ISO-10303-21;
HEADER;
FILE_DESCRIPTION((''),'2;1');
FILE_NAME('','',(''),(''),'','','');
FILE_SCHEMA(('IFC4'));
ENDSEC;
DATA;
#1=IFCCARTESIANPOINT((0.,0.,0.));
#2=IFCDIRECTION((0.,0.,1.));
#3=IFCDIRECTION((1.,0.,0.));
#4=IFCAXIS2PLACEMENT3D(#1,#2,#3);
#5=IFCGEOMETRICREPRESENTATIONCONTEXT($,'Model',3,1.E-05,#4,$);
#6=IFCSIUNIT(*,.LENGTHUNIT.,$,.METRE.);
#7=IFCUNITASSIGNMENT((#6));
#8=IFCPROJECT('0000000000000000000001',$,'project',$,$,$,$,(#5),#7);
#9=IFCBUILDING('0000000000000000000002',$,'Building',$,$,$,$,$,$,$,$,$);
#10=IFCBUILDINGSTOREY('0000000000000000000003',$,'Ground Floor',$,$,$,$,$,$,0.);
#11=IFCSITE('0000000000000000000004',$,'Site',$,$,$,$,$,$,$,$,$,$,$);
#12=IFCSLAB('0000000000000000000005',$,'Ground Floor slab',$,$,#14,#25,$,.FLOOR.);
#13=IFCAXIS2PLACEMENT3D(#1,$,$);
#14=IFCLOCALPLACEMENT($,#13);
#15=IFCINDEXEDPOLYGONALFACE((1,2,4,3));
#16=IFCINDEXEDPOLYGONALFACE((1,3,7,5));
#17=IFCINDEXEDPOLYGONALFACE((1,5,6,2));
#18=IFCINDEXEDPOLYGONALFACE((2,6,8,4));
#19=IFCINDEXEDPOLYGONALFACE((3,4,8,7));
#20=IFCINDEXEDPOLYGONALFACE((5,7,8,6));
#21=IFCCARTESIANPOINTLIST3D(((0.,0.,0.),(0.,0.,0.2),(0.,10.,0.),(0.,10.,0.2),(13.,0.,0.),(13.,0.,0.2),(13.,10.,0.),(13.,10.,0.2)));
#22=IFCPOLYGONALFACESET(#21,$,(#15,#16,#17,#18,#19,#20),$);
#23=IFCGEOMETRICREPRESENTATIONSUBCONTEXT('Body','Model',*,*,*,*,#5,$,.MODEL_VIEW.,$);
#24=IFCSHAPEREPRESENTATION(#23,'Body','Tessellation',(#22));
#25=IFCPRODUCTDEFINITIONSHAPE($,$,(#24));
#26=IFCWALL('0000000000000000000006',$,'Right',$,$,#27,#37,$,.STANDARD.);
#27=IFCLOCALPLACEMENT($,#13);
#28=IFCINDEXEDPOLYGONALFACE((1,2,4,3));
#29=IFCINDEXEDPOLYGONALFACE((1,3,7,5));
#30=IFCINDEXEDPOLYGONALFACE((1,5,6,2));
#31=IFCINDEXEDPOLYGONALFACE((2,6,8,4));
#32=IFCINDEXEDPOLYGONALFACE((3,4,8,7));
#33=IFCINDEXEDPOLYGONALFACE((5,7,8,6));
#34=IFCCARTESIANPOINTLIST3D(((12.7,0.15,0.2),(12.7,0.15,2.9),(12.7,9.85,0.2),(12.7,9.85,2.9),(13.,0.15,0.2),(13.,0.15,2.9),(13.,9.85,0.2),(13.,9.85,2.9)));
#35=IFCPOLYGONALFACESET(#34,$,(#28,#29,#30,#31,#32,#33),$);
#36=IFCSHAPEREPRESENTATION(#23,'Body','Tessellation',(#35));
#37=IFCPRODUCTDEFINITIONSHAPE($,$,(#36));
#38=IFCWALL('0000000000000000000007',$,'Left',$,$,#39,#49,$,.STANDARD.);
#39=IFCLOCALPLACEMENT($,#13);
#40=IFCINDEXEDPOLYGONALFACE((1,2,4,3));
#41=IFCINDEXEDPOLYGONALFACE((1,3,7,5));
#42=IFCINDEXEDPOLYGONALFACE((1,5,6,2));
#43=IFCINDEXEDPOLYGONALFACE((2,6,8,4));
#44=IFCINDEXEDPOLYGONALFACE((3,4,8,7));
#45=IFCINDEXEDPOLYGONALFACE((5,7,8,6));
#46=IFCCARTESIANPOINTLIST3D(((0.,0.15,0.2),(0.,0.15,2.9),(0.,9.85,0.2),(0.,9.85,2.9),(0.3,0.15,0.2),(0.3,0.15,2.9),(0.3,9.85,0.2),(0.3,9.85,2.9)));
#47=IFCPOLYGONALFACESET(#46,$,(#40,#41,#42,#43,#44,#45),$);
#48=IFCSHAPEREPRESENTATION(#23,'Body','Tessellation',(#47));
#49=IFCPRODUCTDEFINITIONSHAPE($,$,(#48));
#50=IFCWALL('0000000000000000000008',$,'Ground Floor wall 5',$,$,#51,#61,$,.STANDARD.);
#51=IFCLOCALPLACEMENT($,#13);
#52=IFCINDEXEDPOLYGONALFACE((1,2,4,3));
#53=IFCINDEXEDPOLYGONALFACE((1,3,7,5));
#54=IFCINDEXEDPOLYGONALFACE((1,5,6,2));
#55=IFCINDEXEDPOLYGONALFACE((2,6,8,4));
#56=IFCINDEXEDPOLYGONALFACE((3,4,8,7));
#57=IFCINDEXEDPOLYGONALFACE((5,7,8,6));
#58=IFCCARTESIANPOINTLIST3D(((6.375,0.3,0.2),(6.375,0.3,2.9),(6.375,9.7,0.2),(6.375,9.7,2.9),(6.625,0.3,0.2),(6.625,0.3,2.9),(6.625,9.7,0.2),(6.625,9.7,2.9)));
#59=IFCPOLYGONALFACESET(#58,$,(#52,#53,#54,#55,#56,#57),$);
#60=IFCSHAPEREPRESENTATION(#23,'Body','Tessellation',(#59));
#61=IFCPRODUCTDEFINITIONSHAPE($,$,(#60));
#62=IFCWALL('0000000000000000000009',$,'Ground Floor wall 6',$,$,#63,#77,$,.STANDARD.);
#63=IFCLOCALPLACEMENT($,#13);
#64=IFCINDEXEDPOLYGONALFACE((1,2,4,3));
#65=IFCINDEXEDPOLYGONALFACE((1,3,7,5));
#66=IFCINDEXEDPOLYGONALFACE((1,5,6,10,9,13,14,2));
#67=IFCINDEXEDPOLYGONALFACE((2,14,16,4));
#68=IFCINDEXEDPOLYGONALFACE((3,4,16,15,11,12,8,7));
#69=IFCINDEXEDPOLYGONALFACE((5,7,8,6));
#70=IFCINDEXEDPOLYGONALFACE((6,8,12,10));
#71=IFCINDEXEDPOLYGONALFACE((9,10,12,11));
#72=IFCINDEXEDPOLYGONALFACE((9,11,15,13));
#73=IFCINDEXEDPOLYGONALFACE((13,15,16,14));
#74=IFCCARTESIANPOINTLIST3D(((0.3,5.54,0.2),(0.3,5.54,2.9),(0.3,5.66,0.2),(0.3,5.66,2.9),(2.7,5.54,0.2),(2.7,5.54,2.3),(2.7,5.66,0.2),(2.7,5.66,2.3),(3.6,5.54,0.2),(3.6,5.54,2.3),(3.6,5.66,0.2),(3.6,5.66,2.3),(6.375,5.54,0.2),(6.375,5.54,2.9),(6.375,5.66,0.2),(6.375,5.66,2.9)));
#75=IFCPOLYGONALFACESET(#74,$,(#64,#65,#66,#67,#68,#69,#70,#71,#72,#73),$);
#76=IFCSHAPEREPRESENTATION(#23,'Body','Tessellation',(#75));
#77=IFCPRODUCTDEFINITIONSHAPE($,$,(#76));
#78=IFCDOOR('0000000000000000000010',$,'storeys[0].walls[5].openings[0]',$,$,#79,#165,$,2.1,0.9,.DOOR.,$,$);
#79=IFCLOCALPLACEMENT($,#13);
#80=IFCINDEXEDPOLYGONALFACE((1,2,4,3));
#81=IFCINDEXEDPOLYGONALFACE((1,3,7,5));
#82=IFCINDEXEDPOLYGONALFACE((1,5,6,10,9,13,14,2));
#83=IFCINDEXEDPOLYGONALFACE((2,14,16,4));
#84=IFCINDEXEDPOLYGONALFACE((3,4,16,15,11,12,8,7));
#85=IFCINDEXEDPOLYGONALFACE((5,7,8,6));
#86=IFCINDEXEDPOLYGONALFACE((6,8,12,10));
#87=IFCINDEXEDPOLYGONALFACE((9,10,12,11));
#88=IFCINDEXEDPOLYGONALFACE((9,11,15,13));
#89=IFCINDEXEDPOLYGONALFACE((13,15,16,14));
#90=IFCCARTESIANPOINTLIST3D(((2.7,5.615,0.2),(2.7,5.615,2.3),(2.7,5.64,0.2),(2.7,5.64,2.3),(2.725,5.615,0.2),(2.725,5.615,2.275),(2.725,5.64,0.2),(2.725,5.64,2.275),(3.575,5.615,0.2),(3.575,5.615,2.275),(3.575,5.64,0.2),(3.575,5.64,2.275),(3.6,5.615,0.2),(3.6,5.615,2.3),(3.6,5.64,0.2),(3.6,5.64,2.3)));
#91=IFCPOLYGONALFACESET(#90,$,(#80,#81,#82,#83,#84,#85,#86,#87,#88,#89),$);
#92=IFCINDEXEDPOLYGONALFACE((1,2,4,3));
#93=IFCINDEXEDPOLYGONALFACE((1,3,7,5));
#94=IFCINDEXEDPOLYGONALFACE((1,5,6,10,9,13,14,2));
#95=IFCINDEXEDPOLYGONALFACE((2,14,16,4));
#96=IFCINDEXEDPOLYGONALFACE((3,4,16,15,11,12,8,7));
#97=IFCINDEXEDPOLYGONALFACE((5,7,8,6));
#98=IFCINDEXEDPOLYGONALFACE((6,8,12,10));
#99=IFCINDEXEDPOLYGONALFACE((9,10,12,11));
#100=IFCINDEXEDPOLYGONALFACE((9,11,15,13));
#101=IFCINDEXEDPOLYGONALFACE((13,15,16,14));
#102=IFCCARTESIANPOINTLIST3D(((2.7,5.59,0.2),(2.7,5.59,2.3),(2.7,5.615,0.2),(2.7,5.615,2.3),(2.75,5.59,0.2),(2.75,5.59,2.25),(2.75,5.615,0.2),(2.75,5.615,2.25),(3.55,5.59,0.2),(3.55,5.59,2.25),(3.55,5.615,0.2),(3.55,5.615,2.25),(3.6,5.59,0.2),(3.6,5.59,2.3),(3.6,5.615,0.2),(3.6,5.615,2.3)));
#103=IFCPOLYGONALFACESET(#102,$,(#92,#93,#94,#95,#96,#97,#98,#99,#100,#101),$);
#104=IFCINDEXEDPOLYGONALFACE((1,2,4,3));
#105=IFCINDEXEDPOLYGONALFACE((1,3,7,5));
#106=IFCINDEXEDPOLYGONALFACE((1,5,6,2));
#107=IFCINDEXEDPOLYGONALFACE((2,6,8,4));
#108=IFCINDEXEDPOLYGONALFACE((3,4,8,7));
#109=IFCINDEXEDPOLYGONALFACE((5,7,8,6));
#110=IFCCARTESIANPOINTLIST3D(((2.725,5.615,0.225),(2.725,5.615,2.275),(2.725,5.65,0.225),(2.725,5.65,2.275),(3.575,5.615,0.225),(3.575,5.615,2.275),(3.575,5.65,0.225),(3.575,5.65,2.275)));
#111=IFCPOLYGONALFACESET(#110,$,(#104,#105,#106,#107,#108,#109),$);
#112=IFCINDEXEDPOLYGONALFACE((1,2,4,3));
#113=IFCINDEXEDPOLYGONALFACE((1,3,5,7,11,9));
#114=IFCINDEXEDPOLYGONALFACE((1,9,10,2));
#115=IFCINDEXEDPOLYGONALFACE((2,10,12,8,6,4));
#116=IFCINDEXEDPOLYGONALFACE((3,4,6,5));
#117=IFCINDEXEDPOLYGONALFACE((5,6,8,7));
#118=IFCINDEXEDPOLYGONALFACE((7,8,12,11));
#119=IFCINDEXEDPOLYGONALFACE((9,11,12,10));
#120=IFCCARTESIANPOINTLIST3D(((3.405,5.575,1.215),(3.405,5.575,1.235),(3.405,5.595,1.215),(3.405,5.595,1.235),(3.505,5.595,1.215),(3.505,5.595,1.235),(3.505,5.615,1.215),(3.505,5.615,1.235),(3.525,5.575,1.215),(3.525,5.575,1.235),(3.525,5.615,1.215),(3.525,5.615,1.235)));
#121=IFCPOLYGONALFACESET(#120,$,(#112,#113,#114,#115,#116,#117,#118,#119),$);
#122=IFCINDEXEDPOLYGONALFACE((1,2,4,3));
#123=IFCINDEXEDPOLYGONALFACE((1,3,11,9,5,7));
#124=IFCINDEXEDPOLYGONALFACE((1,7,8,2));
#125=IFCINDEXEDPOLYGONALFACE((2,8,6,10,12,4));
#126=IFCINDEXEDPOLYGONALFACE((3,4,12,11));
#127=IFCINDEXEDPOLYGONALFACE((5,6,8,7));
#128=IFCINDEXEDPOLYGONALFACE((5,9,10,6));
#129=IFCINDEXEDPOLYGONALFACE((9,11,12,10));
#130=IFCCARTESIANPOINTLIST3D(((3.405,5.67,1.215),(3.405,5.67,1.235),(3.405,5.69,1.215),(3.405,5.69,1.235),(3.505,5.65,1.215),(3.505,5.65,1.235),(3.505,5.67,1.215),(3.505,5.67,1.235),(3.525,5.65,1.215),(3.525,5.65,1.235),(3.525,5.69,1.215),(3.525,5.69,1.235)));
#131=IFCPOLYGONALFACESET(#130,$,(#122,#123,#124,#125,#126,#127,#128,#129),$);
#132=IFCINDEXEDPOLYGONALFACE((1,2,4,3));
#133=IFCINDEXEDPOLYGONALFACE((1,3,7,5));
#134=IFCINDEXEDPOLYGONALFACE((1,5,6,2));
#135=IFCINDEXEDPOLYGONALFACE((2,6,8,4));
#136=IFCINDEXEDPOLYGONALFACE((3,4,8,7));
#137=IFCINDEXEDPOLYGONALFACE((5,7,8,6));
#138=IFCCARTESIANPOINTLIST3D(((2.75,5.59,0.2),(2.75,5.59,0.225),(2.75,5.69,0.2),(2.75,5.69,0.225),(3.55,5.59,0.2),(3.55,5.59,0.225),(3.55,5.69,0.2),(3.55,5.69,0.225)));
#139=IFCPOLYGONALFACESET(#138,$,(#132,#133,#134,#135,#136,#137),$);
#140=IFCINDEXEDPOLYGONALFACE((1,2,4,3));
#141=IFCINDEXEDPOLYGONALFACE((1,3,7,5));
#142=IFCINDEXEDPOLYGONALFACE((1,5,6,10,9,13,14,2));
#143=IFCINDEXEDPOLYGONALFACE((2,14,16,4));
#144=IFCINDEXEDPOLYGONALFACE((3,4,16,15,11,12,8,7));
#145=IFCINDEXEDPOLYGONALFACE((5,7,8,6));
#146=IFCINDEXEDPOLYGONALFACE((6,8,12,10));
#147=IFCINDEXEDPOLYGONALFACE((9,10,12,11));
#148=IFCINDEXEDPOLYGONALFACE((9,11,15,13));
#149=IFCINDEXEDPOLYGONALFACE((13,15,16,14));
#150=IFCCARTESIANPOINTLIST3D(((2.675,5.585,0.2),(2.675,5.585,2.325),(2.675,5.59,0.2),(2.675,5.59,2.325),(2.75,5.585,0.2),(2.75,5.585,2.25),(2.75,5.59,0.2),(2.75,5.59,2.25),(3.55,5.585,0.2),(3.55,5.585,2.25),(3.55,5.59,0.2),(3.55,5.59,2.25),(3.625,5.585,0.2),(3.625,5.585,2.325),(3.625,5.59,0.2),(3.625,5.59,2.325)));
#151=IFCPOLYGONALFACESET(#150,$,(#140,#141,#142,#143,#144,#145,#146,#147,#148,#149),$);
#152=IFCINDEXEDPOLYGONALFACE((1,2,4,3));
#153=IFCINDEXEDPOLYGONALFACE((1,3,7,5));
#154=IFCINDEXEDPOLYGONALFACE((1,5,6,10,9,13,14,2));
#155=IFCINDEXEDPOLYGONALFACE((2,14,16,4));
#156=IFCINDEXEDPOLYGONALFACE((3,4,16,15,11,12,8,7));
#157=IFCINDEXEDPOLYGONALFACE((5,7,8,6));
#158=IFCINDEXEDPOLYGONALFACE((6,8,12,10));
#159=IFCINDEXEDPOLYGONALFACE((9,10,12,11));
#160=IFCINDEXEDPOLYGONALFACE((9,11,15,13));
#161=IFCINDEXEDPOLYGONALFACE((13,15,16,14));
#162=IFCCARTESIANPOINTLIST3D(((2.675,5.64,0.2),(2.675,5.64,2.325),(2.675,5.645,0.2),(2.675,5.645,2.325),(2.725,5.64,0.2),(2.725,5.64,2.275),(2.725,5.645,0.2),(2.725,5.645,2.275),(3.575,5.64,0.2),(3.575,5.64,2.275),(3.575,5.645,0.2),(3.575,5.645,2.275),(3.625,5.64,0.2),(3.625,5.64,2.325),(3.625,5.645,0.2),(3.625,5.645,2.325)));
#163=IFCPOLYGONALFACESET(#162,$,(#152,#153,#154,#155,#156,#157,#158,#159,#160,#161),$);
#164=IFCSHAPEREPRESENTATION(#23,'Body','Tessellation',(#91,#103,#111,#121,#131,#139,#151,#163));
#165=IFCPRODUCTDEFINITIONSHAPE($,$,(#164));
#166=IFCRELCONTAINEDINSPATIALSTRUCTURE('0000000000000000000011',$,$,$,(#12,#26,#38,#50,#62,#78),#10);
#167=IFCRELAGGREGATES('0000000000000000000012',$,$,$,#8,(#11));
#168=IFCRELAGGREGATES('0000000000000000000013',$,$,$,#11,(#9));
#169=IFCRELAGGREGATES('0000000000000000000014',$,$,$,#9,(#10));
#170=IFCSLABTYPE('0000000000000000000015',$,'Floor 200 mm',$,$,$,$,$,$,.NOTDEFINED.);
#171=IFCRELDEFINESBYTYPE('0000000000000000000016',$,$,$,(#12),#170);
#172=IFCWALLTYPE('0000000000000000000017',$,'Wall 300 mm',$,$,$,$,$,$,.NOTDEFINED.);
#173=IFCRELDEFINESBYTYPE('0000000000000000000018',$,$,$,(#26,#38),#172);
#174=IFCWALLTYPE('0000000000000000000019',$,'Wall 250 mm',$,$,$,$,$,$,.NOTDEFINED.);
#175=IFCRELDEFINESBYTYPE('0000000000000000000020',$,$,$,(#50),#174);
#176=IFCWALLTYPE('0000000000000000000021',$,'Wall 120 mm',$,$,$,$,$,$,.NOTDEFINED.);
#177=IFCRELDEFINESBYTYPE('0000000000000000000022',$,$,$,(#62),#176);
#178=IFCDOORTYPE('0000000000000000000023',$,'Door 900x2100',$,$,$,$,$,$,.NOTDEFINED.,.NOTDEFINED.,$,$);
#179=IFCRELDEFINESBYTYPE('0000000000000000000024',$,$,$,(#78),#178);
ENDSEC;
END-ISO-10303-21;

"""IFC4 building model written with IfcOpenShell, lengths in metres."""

from ifc_helpers import new_model, si_unit, frame, origin_with_axes, place, context, subcontext, project, spatial, line, indexed_curve, outline, extrude, type_object, element, fill, save


model = new_model("IFC4")

# Units and contexts
model_context = context("Model", 3, precision=1e-05, world=origin_with_axes())
body_context = subcontext(model_context, "Body", "Model", "MODEL_VIEW")
ifc_project = project(units=[si_unit("LENGTHUNIT", "METRE")], contexts=[model_context])

# Site, building, storey
site = spatial("IfcSite", under=ifc_project, Name="Site")
building = spatial("IfcBuilding", under=site, Name="Building")
storey = spatial("IfcBuildingStorey", under=building, Name="Ground Floor", Elevation=0.0)

# Slab
slab_type = type_object("IfcSlabType", Name="Floor 200 mm", PredefinedType="NOTDEFINED")
slab_placement = place(None, origin_with_axes())
element("IfcSlab", 1, at=slab_placement, inside=storey, type_object=slab_type, Name="Ground Floor slab", PredefinedType="FLOOR", context=body_context, shape_type="SweptSolid", body=[
    extrude(outline(indexed_curve([(0.0, 0.0), (13.0, 0.0), (13.0, 10.0), (0.0, 10.0)])), None, (0.0, 0.0, 1.0), 0.2),
])

# Shared definitions
wall_type_1 = type_object("IfcWallType", Name="Wall 300 mm", PredefinedType="NOTDEFINED")

# Wall
wall_1_placement = place(None, frame((12.85, 0.15, 0.2), z_axis=(0.0, 0.0, 1.0), x_axis=(0.0, 1.0, 0.0)))
element("IfcWall", 2, at=wall_1_placement, inside=storey, type_object=wall_type_1, Name="Right", PredefinedType="STANDARD", context=body_context, shape_type="SweptSolid", body=[
    extrude(outline(indexed_curve([(0.0, 0.0), (0.0, 0.3), (9.7, 0.3), (9.7, 0.0), (0.0, 0.0)], self_intersect=False)), frame((0.0, -0.15, 0.0), z_axis=(0.0, 0.0, 1.0), x_axis=(1.0, 0.0, 0.0)), (0.0, 0.0, 1.0), 2.7),
])

# Walls
wall_2_placement = place(None, frame((0.15, 9.85, 0.2), z_axis=(0.0, 0.0, 1.0), x_axis=(0.0, -1.0, 0.0)))
element("IfcWall", 3, at=wall_2_placement, inside=storey, type_object=wall_type_1, Name="Left", PredefinedType="STANDARD", context=body_context, shape_type="SweptSolid", body=[
    extrude(outline(indexed_curve([(0.0, 0.0), (0.0, 0.3), (9.7, 0.3), (9.7, 0.0), (0.0, 0.0)], self_intersect=False)), frame((0.0, -0.15, 0.0), z_axis=(0.0, 0.0, 1.0), x_axis=(1.0, 0.0, 0.0)), (0.0, 0.0, 1.0), 2.7),
])
wall_type_2 = type_object("IfcWallType", Name="Wall 250 mm", PredefinedType="NOTDEFINED")
wall_3_placement = place(None, frame((6.5, 0.3, 0.2), z_axis=(0.0, 0.0, 1.0), x_axis=(0.0, 1.0, 0.0)))
element("IfcWall", 4, at=wall_3_placement, inside=storey, type_object=wall_type_2, Name="Ground Floor wall 5", PredefinedType="STANDARD", context=body_context, shape_type="SweptSolid", body=[
    extrude(outline(indexed_curve([(0.0, 0.0), (0.0, 0.25), (9.4, 0.25), (9.4, 0.0), (0.0, 0.0)], self_intersect=False)), frame((0.0, -0.125, 0.0), z_axis=(0.0, 0.0, 1.0), x_axis=(1.0, 0.0, 0.0)), (0.0, 0.0, 1.0), 2.7),
])

# Wall, opening, door
wall_type_3 = type_object("IfcWallType", Name="Wall 120 mm", PredefinedType="NOTDEFINED")
wall_4_placement = place(None, frame((0.3, 5.6, 0.2), z_axis=(0.0, 0.0, 1.0), x_axis=(1.0, 0.0, 0.0)))
wall_4 = element("IfcWall", 5, at=wall_4_placement, inside=storey, type_object=wall_type_3, Name="Ground Floor wall 6", PredefinedType="STANDARD", context=body_context, shape_type="SweptSolid", body=[
    extrude(outline(indexed_curve([(0.0, 0.0), (0.0, 0.12), (6.075, 0.12), (6.075, 0.0), (0.0, 0.0)], self_intersect=False)), frame((0.0, -0.06, 0.0), z_axis=(0.0, 0.0, 1.0), x_axis=(1.0, 0.0, 0.0)), (0.0, 0.0, 1.0), 2.7),
])
opening_1_placement = place(wall_4_placement, frame((2.4, -0.07, 0.0), z_axis=(0.0, 0.0, 1.0), x_axis=(1.0, 0.0, 0.0)))
opening_1 = element("IfcOpeningElement", 6, at=opening_1_placement, cuts=wall_4, context=body_context, shape_type="SweptSolid", body=[
    extrude(outline(indexed_curve([(0.0, 0.0), (0.0, 0.14), (0.9, 0.14), (0.9, 0.0), (0.0, 0.0)], self_intersect=False)), origin_with_axes(), (0.0, 0.0, 1.0), 2.1),
])
door_type_1 = type_object("IfcDoorType", Name="Door 900x2100", OperationType="NOTDEFINED", PredefinedType="NOTDEFINED")
door_1_placement = place(None, frame((2.7, 5.59, 0.2), z_axis=(0.0, 0.0, 1.0), x_axis=(1.0, 0.0, 0.0)))
door_1 = element("IfcDoor", 7, at=door_1_placement, inside=storey, type_object=door_type_1, Name="storeys[0].walls[5].openings[0]", OverallHeight=2.1, OverallWidth=0.9, PredefinedType="DOOR", context=body_context, shape_type="SweptSolid", body=[
    extrude(outline(indexed_curve([(0.0, 0.0), (0.0, 2.1), (0.9, 2.1), (0.9, 0.0), (0.875, 0.0), (0.875, 2.075), (0.025, 2.075), (0.025, 0.0)], segments=[line(1, 2, 3, 4, 5, 6, 7, 8, 1)])), frame((0.0, 0.025, 0.0), z_axis=(0.0, -1.0, 0.0), x_axis=(1.0, 0.0, 0.0)), (0.0, 0.0, -1.0), 0.025),
    extrude(outline(indexed_curve([(0.0, 0.0), (0.0, 2.1), (0.9, 2.1), (0.9, 0.0), (0.85, 0.0), (0.85, 2.05), (0.05, 2.05), (0.05, 0.0)], segments=[line(1, 2, 3, 4, 5, 6, 7, 8, 1)])), frame((0.0, 0.0, 0.0), z_axis=(0.0, -1.0, 0.0), x_axis=(1.0, 0.0, 0.0)), (0.0, 0.0, -1.0), 0.025),
    extrude(outline(indexed_curve([(0.0, 0.0), (0.85, 0.0), (0.85, 0.035), (0.0, 0.035)], segments=[line(1, 2, 3, 4, 1)])), frame((0.025, 0.025, 0.025), z_axis=(0.0, 0.0, 1.0), x_axis=(1.0, 0.0, 0.0)), (0.0, 0.0, 1.0), 2.05),
    extrude(outline(indexed_curve([(0.0, 0.0), (0.0, -0.04), (-0.12, -0.04), (-0.12, -0.02), (-0.02, -0.02), (-0.02, 0.0)], segments=[line(1, 2, 3, 4, 5, 6, 1)])), frame((0.825, 0.025, 1.015), z_axis=(0.0, 0.0, 1.0), x_axis=(1.0, 0.0, 0.0)), (0.0, 0.0, 1.0), 0.02),
    extrude(outline(indexed_curve([(0.0, 0.0), (0.0, 0.04), (-0.12, 0.04), (-0.12, 0.02), (-0.02, 0.02), (-0.02, 0.0)], segments=[line(1, 2, 3, 4, 5, 6, 1)])), frame((0.825, 0.06, 1.015), z_axis=(0.0, 0.0, 1.0), x_axis=(1.0, 0.0, 0.0)), (0.0, 0.0, 1.0), 0.02),
    extrude(outline(indexed_curve([(0.0, 0.0), (0.8, 0.0), (0.8, 0.1), (0.0, 0.1)], segments=[line(1, 2, 3, 4, 1)])), frame((0.05, 0.0, 0.0), z_axis=(0.0, 0.0, 1.0), x_axis=(1.0, 0.0, 0.0)), (0.0, 0.0, 1.0), 0.025),
    extrude(outline(indexed_curve([(0.0, 0.0), (0.0, 2.125), (0.95, 2.125), (0.95, 0.0), (0.875, 0.0), (0.875, 2.05), (0.075, 2.05), (0.075, 0.0)], segments=[line(1, 2, 3, 4, 5, 6, 7, 8, 1)])), frame((-0.025, -0.005, 0.0), z_axis=(0.0, -1.0, 0.0), x_axis=(1.0, 0.0, 0.0)), (0.0, 0.0, -1.0), 0.005),
    extrude(outline(indexed_curve([(0.0, 0.0), (0.0, 2.125), (0.95, 2.125), (0.95, 0.0), (0.9, 0.0), (0.9, 2.075), (0.05, 2.075), (0.05, 0.0)], segments=[line(1, 2, 3, 4, 5, 6, 7, 8, 1)])), frame((-0.025, 0.05, 0.0), z_axis=(0.0, -1.0, 0.0), x_axis=(1.0, 0.0, 0.0)), (0.0, 0.0, -1.0), 0.005),
])
fill(opening_1, door_1)

save(model, "model.ifc")
